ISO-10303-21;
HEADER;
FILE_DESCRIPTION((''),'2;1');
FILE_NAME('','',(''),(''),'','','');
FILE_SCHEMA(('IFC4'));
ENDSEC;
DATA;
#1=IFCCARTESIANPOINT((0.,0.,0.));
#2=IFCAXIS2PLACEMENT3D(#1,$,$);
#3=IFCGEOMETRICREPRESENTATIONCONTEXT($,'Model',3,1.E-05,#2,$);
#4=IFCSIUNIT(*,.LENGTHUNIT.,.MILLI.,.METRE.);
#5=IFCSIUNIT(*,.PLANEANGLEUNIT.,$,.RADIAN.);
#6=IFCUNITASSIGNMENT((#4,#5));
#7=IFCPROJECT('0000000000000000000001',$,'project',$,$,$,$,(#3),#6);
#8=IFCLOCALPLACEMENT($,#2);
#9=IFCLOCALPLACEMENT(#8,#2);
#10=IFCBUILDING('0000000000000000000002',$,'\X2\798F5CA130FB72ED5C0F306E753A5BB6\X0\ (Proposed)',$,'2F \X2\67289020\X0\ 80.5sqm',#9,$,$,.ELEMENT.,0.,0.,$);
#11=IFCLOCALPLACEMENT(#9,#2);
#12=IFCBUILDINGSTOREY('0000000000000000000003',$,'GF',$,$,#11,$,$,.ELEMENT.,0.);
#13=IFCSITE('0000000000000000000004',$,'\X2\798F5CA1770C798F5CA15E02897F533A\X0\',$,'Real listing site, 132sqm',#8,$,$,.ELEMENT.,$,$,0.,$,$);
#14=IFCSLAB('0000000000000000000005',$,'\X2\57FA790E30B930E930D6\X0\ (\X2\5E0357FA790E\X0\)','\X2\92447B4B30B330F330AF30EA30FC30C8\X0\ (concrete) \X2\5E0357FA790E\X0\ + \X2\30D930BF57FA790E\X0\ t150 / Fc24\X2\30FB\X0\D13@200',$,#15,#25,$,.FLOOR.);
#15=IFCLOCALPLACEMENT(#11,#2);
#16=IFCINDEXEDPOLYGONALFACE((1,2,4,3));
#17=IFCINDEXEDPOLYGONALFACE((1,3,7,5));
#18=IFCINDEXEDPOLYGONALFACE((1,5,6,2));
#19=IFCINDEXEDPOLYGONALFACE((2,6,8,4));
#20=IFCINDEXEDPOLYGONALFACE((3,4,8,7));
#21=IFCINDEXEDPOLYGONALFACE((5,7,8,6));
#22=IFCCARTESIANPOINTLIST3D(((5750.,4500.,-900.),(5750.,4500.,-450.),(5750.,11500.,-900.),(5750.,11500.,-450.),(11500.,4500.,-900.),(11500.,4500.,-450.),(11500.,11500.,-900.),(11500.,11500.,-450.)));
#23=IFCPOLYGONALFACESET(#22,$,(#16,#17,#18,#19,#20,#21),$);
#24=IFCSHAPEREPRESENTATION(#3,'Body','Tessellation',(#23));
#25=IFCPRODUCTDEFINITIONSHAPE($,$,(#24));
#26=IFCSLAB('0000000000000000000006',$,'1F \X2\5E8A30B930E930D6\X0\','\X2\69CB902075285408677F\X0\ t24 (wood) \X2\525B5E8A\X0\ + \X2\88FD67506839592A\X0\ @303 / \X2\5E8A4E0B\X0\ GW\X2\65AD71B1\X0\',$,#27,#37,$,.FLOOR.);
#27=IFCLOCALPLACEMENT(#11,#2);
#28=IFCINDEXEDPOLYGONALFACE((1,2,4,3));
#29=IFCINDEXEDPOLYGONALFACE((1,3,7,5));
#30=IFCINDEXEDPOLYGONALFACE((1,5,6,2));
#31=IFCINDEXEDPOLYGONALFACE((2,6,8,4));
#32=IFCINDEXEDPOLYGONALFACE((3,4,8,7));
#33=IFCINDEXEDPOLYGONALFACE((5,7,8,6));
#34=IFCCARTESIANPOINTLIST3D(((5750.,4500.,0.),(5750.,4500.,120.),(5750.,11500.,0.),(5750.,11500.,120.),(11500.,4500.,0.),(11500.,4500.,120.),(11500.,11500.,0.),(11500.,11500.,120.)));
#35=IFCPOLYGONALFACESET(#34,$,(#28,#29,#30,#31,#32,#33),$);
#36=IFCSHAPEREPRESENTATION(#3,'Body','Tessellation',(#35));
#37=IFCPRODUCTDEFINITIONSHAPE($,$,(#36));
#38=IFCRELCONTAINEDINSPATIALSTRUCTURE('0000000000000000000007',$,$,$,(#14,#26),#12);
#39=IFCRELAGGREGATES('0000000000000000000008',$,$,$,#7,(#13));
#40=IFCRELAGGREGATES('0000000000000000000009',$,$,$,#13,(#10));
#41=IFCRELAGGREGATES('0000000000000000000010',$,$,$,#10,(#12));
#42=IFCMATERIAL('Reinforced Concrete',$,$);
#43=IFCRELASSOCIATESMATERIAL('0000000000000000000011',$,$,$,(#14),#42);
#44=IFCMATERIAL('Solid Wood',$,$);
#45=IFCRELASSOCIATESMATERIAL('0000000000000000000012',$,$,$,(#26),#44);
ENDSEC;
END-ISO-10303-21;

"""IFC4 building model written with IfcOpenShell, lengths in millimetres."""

from ifc_helpers import new_model, si_unit, frame, frame_2d, origin, place, context, project, spatial, rectangle, extrude, material, element, save


model = new_model("IFC4")

# Units and contexts
model_context = context("Model", 3, precision=1e-05, world=origin())
ifc_project = project(units=[si_unit("LENGTHUNIT", "METRE", prefix="MILLI"), si_unit("PLANEANGLEUNIT", "RADIAN")], contexts=[model_context])

# Site, building, storey
site_placement = place(None, origin())
site = spatial("IfcSite", under=ifc_project, at=site_placement, Name="福岡県福岡市西区", ObjectType="Real listing site, 132sqm", CompositionType="ELEMENT", RefElevation=0.0)
building_placement = place(site_placement, origin())
building = spatial("IfcBuilding", under=site, at=building_placement, Name="福岡・狭小の町家 (Proposed)", ObjectType="2F 木造 80.5sqm", CompositionType="ELEMENT", ElevationOfRefHeight=0.0, ElevationOfTerrain=0.0)
storey_placement = place(building_placement, origin())
storey = spatial("IfcBuildingStorey", under=building, at=storey_placement, Name="GF", CompositionType="ELEMENT", Elevation=0.0)

# Shared definitions
ifc_material_1 = material(Name="Solid Wood")

# Slabs
ifc_material_2 = material(Name="Reinforced Concrete")
slab_1_placement = place(storey_placement, frame((2875.0, 2250.0, -450.0)))
element("IfcSlab", 1, at=slab_1_placement, inside=storey, material=ifc_material_2, Name="基礎スラブ (布基礎)", Description="鉄筋コンクリート (concrete) 布基礎 + ベタ基礎 t150 / Fc24・D13@200", PredefinedType="FLOOR", context=model_context, shape_type="SweptSolid", body=[
    extrude(rectangle(XDim=5750.0, YDim=7000.0, at=frame_2d((2875.0, 3500.0))), frame((2875.0, 2250.0, -450.0)), (0.0, 0.0, 1.0), 450.0),
])
slab_2_placement = place(storey_placement, frame((2875.0, 2250.0, 0.0)))
element("IfcSlab", 2, at=slab_2_placement, inside=storey, material=ifc_material_1, Name="1F 床スラブ", Description="構造用合板 t24 (wood) 剛床 + 製材根太 @303 / 床下 GW断熱", PredefinedType="FLOOR", context=model_context, shape_type="SweptSolid", body=[
    extrude(rectangle(XDim=5750.0, YDim=7000.0, at=frame_2d((2875.0, 3500.0))), frame((2875.0, 2250.0, 0.0)), (0.0, 0.0, 1.0), 120.0),
])

save(model, "model.ifc")
